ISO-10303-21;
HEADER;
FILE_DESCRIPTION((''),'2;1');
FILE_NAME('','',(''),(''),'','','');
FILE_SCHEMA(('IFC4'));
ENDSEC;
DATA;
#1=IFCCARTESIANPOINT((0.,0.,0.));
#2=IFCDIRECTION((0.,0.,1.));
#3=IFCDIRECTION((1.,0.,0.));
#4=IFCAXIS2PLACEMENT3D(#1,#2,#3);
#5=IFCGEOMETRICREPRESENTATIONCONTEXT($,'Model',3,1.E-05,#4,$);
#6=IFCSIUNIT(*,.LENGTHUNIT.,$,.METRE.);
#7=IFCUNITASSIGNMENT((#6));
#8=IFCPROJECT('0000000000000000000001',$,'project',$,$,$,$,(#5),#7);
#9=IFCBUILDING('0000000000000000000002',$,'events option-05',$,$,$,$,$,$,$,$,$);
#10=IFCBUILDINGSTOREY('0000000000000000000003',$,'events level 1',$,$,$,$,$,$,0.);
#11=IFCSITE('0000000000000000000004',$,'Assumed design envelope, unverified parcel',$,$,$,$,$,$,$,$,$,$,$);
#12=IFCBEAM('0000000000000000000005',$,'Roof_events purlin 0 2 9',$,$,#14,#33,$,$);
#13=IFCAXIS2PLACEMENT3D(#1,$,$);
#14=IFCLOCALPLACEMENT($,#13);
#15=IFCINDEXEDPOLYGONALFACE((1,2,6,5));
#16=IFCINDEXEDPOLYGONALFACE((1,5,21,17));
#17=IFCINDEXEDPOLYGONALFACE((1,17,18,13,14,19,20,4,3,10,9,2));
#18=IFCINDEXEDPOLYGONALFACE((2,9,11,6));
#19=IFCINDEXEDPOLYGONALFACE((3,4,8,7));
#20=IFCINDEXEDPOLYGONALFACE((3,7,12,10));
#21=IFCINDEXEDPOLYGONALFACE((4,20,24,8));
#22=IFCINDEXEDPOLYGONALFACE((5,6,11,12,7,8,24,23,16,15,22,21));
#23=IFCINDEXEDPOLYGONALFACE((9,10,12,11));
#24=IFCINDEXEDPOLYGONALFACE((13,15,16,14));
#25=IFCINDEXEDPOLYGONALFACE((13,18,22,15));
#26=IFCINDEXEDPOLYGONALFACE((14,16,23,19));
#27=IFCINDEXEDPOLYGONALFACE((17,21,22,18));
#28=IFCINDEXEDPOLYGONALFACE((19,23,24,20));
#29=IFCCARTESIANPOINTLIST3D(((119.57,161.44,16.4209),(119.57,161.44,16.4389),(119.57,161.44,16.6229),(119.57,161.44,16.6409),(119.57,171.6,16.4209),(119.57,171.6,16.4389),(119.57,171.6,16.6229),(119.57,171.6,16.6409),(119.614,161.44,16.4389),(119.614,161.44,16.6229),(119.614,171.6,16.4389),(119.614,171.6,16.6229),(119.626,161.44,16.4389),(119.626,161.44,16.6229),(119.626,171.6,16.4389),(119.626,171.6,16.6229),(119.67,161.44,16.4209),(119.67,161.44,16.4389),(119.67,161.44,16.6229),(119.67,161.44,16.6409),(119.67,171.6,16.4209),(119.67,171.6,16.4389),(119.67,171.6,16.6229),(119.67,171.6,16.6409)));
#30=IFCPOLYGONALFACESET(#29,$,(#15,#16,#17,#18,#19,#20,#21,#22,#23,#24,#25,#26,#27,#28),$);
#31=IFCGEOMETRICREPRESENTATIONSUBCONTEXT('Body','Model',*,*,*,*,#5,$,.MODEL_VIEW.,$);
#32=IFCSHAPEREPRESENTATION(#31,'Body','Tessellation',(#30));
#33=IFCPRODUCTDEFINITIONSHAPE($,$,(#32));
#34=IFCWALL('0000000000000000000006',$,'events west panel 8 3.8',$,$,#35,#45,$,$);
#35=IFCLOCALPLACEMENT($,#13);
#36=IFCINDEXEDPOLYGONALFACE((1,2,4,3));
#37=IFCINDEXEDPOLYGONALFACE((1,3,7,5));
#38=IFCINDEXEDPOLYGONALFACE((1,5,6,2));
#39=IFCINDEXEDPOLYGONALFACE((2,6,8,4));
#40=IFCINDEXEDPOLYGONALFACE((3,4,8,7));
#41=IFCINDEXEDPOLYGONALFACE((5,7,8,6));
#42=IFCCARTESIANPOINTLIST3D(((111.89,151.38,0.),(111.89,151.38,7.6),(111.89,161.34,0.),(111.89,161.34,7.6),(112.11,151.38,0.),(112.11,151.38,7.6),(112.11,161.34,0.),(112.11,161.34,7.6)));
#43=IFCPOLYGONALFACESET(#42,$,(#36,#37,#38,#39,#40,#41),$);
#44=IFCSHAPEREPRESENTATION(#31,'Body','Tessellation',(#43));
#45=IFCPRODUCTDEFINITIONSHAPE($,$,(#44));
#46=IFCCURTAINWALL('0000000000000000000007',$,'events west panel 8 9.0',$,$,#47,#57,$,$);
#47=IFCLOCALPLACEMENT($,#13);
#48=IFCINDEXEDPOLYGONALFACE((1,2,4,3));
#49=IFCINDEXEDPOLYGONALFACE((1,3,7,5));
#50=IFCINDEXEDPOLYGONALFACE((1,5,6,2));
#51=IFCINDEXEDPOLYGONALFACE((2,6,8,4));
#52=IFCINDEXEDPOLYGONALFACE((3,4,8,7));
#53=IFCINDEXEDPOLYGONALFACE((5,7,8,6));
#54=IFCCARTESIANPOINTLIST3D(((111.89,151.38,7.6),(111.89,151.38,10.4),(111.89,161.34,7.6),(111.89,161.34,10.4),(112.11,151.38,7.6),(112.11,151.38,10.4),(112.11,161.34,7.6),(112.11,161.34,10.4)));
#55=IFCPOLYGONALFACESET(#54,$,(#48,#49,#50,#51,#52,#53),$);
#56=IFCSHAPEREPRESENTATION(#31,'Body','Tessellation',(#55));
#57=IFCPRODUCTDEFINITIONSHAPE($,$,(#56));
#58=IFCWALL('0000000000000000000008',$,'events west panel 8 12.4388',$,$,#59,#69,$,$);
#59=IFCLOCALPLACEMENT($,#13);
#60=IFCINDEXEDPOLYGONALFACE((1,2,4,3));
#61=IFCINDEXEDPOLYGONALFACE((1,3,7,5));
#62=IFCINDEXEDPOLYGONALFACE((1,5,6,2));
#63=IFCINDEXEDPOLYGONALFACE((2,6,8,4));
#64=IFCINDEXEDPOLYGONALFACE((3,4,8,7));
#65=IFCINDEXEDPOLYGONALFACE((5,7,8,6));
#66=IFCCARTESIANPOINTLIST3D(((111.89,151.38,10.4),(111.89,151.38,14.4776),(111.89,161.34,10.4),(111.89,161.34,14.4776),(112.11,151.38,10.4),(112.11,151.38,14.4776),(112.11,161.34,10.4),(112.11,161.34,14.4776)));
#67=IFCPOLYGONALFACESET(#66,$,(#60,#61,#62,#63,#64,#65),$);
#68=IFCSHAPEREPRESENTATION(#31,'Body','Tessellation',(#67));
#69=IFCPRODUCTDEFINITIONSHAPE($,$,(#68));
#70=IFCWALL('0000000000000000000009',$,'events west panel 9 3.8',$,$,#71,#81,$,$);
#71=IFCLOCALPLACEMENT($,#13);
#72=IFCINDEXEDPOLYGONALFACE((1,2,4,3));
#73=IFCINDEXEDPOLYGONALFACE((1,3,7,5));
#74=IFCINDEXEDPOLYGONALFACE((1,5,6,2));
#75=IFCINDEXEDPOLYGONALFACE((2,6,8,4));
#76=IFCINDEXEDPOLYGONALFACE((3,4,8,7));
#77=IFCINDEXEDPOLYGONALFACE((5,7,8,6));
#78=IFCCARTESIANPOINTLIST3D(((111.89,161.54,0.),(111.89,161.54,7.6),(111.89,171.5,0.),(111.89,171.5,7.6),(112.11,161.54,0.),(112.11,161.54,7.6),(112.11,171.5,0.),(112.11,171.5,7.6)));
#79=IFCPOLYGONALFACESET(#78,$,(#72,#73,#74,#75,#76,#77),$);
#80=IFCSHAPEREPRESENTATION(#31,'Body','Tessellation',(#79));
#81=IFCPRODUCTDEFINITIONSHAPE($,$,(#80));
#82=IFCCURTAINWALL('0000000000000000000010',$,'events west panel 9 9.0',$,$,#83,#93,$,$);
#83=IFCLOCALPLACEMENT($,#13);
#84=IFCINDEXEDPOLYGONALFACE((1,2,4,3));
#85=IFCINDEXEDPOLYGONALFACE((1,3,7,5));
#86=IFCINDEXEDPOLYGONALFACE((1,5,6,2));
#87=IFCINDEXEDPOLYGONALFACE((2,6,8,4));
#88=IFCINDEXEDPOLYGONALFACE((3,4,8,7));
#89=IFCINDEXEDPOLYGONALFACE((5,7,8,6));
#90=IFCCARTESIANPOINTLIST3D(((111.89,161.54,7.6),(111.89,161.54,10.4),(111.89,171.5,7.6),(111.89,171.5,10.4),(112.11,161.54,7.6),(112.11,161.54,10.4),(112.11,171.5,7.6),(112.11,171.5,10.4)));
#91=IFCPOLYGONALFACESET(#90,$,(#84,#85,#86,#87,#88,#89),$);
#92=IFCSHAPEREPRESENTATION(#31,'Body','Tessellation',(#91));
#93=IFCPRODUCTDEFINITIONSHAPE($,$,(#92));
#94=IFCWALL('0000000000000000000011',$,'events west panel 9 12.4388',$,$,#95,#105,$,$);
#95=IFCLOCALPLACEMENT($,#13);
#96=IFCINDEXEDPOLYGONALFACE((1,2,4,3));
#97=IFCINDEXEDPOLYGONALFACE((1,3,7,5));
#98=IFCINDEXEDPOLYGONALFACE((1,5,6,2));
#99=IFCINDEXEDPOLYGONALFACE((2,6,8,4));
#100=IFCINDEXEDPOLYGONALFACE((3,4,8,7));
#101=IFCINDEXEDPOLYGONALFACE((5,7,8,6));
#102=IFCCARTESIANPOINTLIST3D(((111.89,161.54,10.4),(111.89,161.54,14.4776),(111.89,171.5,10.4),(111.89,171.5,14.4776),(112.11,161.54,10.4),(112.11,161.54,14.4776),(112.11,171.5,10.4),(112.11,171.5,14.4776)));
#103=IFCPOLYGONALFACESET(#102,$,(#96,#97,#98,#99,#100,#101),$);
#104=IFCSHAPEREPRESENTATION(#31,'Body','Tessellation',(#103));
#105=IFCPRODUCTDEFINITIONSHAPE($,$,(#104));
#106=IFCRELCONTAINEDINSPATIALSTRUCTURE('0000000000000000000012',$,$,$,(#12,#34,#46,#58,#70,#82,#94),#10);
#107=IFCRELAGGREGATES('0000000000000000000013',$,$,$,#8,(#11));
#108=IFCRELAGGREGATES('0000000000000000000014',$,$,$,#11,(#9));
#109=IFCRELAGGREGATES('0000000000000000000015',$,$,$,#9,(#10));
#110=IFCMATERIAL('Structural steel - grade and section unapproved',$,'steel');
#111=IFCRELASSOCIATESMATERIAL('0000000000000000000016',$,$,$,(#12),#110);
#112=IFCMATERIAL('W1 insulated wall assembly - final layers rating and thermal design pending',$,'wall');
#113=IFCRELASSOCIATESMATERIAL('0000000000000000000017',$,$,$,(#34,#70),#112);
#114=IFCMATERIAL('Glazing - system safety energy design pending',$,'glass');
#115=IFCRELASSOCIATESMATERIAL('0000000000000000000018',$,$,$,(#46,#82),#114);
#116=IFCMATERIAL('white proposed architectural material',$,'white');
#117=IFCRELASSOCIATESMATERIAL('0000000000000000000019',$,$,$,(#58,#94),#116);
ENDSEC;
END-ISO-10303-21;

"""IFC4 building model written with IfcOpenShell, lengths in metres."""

from ifc_helpers import new_model, si_unit, frame, origin_with_axes, place, context, subcontext, project, spatial, rectangle, i_section, extrude, material, element, save


model = new_model("IFC4")

# Units and contexts
model_context = context("Model", 3, precision=1e-05, world=origin_with_axes())
body_context = subcontext(model_context, "Body", "Model", "MODEL_VIEW")
ifc_project = project(units=[si_unit("LENGTHUNIT", "METRE")], contexts=[model_context])

# Site, building, storey
site = spatial("IfcSite", under=ifc_project, Name="Assumed design envelope, unverified parcel")
building = spatial("IfcBuilding", under=site, Name="events option-05")
storey = spatial("IfcBuildingStorey", under=building, Name="events level 1", Elevation=0.0)

# Shared definitions
ifc_material_1 = material(Name="Structural steel - grade and section unapproved", Category="steel")

# Beam
for number, where, z_axis, x_axis, name in (
    (1, (119.62, 161.44, 16.5309), (0.0, 1.0, 0.0), (-1.0, 0.0, 0.0), "Roof_events purlin 0 2 9"),
):
    element("IfcBeam", number, at=place(None, frame(where, z_axis=z_axis, x_axis=x_axis)), inside=storey, material=ifc_material_1, Name=name, context=body_context, shape_type="SweptSolid", body=[
        extrude(i_section(OverallWidth=0.1, OverallDepth=0.22, WebThickness=0.012, FlangeThickness=0.018, FilletRadius=0.0), origin_with_axes(), (0.0, 0.0, 1.0), 10.16),
    ])

# Wall
ifc_material_2 = material(Name="W1 insulated wall assembly - final layers rating and thermal design pending", Category="wall")
wall_1_placement = place(None, frame((112.0, 156.36, 0.0), z_axis=(0.0, 0.0, 1.0), x_axis=(1.0, 0.0, 0.0)))
element("IfcWall", 2, at=wall_1_placement, inside=storey, material=ifc_material_2, Name="events west panel 8 3.8", context=body_context, shape_type="SweptSolid", body=[
    extrude(rectangle(XDim=0.22, YDim=9.96), origin_with_axes(), (0.0, 0.0, 1.0), 7.6),
])

# Curtain wall
ifc_material_3 = material(Name="Glazing - system safety energy design pending", Category="glass")
curtain_wall_1_placement = place(None, frame((112.0, 156.36, 7.6), z_axis=(0.0, 0.0, 1.0), x_axis=(1.0, 0.0, 0.0)))
element("IfcCurtainWall", 3, at=curtain_wall_1_placement, inside=storey, material=ifc_material_3, Name="events west panel 8 9.0", context=body_context, shape_type="SweptSolid", body=[
    extrude(rectangle(XDim=0.22, YDim=9.96), origin_with_axes(), (0.0, 0.0, 1.0), 2.8),
])

# Walls
ifc_material_4 = material(Name="white proposed architectural material", Category="white")
wall_2_placement = place(None, frame((112.0, 156.36, 10.4), z_axis=(0.0, 0.0, 1.0), x_axis=(1.0, 0.0, 0.0)))
element("IfcWall", 4, at=wall_2_placement, inside=storey, material=ifc_material_4, Name="events west panel 8 12.4388", context=body_context, shape_type="SweptSolid", body=[
    extrude(rectangle(XDim=0.22, YDim=9.96), origin_with_axes(), (0.0, 0.0, 1.0), 4.0776),
])
wall_3_placement = place(None, frame((112.0, 166.52, 0.0), z_axis=(0.0, 0.0, 1.0), x_axis=(1.0, 0.0, 0.0)))
element("IfcWall", 5, at=wall_3_placement, inside=storey, material=ifc_material_2, Name="events west panel 9 3.8", context=body_context, shape_type="SweptSolid", body=[
    extrude(rectangle(XDim=0.22, YDim=9.96), origin_with_axes(), (0.0, 0.0, 1.0), 7.6),
])

# Curtain wall
curtain_wall_2_placement = place(None, frame((112.0, 166.52, 7.6), z_axis=(0.0, 0.0, 1.0), x_axis=(1.0, 0.0, 0.0)))
element("IfcCurtainWall", 6, at=curtain_wall_2_placement, inside=storey, material=ifc_material_3, Name="events west panel 9 9.0", context=body_context, shape_type="SweptSolid", body=[
    extrude(rectangle(XDim=0.22, YDim=9.96), origin_with_axes(), (0.0, 0.0, 1.0), 2.8),
])

# Wall
wall_4_placement = place(None, frame((112.0, 166.52, 10.4), z_axis=(0.0, 0.0, 1.0), x_axis=(1.0, 0.0, 0.0)))
element("IfcWall", 7, at=wall_4_placement, inside=storey, material=ifc_material_4, Name="events west panel 9 12.4388", context=body_context, shape_type="SweptSolid", body=[
    extrude(rectangle(XDim=0.22, YDim=9.96), origin_with_axes(), (0.0, 0.0, 1.0), 4.0776),
])

save(model, "model.ifc")
